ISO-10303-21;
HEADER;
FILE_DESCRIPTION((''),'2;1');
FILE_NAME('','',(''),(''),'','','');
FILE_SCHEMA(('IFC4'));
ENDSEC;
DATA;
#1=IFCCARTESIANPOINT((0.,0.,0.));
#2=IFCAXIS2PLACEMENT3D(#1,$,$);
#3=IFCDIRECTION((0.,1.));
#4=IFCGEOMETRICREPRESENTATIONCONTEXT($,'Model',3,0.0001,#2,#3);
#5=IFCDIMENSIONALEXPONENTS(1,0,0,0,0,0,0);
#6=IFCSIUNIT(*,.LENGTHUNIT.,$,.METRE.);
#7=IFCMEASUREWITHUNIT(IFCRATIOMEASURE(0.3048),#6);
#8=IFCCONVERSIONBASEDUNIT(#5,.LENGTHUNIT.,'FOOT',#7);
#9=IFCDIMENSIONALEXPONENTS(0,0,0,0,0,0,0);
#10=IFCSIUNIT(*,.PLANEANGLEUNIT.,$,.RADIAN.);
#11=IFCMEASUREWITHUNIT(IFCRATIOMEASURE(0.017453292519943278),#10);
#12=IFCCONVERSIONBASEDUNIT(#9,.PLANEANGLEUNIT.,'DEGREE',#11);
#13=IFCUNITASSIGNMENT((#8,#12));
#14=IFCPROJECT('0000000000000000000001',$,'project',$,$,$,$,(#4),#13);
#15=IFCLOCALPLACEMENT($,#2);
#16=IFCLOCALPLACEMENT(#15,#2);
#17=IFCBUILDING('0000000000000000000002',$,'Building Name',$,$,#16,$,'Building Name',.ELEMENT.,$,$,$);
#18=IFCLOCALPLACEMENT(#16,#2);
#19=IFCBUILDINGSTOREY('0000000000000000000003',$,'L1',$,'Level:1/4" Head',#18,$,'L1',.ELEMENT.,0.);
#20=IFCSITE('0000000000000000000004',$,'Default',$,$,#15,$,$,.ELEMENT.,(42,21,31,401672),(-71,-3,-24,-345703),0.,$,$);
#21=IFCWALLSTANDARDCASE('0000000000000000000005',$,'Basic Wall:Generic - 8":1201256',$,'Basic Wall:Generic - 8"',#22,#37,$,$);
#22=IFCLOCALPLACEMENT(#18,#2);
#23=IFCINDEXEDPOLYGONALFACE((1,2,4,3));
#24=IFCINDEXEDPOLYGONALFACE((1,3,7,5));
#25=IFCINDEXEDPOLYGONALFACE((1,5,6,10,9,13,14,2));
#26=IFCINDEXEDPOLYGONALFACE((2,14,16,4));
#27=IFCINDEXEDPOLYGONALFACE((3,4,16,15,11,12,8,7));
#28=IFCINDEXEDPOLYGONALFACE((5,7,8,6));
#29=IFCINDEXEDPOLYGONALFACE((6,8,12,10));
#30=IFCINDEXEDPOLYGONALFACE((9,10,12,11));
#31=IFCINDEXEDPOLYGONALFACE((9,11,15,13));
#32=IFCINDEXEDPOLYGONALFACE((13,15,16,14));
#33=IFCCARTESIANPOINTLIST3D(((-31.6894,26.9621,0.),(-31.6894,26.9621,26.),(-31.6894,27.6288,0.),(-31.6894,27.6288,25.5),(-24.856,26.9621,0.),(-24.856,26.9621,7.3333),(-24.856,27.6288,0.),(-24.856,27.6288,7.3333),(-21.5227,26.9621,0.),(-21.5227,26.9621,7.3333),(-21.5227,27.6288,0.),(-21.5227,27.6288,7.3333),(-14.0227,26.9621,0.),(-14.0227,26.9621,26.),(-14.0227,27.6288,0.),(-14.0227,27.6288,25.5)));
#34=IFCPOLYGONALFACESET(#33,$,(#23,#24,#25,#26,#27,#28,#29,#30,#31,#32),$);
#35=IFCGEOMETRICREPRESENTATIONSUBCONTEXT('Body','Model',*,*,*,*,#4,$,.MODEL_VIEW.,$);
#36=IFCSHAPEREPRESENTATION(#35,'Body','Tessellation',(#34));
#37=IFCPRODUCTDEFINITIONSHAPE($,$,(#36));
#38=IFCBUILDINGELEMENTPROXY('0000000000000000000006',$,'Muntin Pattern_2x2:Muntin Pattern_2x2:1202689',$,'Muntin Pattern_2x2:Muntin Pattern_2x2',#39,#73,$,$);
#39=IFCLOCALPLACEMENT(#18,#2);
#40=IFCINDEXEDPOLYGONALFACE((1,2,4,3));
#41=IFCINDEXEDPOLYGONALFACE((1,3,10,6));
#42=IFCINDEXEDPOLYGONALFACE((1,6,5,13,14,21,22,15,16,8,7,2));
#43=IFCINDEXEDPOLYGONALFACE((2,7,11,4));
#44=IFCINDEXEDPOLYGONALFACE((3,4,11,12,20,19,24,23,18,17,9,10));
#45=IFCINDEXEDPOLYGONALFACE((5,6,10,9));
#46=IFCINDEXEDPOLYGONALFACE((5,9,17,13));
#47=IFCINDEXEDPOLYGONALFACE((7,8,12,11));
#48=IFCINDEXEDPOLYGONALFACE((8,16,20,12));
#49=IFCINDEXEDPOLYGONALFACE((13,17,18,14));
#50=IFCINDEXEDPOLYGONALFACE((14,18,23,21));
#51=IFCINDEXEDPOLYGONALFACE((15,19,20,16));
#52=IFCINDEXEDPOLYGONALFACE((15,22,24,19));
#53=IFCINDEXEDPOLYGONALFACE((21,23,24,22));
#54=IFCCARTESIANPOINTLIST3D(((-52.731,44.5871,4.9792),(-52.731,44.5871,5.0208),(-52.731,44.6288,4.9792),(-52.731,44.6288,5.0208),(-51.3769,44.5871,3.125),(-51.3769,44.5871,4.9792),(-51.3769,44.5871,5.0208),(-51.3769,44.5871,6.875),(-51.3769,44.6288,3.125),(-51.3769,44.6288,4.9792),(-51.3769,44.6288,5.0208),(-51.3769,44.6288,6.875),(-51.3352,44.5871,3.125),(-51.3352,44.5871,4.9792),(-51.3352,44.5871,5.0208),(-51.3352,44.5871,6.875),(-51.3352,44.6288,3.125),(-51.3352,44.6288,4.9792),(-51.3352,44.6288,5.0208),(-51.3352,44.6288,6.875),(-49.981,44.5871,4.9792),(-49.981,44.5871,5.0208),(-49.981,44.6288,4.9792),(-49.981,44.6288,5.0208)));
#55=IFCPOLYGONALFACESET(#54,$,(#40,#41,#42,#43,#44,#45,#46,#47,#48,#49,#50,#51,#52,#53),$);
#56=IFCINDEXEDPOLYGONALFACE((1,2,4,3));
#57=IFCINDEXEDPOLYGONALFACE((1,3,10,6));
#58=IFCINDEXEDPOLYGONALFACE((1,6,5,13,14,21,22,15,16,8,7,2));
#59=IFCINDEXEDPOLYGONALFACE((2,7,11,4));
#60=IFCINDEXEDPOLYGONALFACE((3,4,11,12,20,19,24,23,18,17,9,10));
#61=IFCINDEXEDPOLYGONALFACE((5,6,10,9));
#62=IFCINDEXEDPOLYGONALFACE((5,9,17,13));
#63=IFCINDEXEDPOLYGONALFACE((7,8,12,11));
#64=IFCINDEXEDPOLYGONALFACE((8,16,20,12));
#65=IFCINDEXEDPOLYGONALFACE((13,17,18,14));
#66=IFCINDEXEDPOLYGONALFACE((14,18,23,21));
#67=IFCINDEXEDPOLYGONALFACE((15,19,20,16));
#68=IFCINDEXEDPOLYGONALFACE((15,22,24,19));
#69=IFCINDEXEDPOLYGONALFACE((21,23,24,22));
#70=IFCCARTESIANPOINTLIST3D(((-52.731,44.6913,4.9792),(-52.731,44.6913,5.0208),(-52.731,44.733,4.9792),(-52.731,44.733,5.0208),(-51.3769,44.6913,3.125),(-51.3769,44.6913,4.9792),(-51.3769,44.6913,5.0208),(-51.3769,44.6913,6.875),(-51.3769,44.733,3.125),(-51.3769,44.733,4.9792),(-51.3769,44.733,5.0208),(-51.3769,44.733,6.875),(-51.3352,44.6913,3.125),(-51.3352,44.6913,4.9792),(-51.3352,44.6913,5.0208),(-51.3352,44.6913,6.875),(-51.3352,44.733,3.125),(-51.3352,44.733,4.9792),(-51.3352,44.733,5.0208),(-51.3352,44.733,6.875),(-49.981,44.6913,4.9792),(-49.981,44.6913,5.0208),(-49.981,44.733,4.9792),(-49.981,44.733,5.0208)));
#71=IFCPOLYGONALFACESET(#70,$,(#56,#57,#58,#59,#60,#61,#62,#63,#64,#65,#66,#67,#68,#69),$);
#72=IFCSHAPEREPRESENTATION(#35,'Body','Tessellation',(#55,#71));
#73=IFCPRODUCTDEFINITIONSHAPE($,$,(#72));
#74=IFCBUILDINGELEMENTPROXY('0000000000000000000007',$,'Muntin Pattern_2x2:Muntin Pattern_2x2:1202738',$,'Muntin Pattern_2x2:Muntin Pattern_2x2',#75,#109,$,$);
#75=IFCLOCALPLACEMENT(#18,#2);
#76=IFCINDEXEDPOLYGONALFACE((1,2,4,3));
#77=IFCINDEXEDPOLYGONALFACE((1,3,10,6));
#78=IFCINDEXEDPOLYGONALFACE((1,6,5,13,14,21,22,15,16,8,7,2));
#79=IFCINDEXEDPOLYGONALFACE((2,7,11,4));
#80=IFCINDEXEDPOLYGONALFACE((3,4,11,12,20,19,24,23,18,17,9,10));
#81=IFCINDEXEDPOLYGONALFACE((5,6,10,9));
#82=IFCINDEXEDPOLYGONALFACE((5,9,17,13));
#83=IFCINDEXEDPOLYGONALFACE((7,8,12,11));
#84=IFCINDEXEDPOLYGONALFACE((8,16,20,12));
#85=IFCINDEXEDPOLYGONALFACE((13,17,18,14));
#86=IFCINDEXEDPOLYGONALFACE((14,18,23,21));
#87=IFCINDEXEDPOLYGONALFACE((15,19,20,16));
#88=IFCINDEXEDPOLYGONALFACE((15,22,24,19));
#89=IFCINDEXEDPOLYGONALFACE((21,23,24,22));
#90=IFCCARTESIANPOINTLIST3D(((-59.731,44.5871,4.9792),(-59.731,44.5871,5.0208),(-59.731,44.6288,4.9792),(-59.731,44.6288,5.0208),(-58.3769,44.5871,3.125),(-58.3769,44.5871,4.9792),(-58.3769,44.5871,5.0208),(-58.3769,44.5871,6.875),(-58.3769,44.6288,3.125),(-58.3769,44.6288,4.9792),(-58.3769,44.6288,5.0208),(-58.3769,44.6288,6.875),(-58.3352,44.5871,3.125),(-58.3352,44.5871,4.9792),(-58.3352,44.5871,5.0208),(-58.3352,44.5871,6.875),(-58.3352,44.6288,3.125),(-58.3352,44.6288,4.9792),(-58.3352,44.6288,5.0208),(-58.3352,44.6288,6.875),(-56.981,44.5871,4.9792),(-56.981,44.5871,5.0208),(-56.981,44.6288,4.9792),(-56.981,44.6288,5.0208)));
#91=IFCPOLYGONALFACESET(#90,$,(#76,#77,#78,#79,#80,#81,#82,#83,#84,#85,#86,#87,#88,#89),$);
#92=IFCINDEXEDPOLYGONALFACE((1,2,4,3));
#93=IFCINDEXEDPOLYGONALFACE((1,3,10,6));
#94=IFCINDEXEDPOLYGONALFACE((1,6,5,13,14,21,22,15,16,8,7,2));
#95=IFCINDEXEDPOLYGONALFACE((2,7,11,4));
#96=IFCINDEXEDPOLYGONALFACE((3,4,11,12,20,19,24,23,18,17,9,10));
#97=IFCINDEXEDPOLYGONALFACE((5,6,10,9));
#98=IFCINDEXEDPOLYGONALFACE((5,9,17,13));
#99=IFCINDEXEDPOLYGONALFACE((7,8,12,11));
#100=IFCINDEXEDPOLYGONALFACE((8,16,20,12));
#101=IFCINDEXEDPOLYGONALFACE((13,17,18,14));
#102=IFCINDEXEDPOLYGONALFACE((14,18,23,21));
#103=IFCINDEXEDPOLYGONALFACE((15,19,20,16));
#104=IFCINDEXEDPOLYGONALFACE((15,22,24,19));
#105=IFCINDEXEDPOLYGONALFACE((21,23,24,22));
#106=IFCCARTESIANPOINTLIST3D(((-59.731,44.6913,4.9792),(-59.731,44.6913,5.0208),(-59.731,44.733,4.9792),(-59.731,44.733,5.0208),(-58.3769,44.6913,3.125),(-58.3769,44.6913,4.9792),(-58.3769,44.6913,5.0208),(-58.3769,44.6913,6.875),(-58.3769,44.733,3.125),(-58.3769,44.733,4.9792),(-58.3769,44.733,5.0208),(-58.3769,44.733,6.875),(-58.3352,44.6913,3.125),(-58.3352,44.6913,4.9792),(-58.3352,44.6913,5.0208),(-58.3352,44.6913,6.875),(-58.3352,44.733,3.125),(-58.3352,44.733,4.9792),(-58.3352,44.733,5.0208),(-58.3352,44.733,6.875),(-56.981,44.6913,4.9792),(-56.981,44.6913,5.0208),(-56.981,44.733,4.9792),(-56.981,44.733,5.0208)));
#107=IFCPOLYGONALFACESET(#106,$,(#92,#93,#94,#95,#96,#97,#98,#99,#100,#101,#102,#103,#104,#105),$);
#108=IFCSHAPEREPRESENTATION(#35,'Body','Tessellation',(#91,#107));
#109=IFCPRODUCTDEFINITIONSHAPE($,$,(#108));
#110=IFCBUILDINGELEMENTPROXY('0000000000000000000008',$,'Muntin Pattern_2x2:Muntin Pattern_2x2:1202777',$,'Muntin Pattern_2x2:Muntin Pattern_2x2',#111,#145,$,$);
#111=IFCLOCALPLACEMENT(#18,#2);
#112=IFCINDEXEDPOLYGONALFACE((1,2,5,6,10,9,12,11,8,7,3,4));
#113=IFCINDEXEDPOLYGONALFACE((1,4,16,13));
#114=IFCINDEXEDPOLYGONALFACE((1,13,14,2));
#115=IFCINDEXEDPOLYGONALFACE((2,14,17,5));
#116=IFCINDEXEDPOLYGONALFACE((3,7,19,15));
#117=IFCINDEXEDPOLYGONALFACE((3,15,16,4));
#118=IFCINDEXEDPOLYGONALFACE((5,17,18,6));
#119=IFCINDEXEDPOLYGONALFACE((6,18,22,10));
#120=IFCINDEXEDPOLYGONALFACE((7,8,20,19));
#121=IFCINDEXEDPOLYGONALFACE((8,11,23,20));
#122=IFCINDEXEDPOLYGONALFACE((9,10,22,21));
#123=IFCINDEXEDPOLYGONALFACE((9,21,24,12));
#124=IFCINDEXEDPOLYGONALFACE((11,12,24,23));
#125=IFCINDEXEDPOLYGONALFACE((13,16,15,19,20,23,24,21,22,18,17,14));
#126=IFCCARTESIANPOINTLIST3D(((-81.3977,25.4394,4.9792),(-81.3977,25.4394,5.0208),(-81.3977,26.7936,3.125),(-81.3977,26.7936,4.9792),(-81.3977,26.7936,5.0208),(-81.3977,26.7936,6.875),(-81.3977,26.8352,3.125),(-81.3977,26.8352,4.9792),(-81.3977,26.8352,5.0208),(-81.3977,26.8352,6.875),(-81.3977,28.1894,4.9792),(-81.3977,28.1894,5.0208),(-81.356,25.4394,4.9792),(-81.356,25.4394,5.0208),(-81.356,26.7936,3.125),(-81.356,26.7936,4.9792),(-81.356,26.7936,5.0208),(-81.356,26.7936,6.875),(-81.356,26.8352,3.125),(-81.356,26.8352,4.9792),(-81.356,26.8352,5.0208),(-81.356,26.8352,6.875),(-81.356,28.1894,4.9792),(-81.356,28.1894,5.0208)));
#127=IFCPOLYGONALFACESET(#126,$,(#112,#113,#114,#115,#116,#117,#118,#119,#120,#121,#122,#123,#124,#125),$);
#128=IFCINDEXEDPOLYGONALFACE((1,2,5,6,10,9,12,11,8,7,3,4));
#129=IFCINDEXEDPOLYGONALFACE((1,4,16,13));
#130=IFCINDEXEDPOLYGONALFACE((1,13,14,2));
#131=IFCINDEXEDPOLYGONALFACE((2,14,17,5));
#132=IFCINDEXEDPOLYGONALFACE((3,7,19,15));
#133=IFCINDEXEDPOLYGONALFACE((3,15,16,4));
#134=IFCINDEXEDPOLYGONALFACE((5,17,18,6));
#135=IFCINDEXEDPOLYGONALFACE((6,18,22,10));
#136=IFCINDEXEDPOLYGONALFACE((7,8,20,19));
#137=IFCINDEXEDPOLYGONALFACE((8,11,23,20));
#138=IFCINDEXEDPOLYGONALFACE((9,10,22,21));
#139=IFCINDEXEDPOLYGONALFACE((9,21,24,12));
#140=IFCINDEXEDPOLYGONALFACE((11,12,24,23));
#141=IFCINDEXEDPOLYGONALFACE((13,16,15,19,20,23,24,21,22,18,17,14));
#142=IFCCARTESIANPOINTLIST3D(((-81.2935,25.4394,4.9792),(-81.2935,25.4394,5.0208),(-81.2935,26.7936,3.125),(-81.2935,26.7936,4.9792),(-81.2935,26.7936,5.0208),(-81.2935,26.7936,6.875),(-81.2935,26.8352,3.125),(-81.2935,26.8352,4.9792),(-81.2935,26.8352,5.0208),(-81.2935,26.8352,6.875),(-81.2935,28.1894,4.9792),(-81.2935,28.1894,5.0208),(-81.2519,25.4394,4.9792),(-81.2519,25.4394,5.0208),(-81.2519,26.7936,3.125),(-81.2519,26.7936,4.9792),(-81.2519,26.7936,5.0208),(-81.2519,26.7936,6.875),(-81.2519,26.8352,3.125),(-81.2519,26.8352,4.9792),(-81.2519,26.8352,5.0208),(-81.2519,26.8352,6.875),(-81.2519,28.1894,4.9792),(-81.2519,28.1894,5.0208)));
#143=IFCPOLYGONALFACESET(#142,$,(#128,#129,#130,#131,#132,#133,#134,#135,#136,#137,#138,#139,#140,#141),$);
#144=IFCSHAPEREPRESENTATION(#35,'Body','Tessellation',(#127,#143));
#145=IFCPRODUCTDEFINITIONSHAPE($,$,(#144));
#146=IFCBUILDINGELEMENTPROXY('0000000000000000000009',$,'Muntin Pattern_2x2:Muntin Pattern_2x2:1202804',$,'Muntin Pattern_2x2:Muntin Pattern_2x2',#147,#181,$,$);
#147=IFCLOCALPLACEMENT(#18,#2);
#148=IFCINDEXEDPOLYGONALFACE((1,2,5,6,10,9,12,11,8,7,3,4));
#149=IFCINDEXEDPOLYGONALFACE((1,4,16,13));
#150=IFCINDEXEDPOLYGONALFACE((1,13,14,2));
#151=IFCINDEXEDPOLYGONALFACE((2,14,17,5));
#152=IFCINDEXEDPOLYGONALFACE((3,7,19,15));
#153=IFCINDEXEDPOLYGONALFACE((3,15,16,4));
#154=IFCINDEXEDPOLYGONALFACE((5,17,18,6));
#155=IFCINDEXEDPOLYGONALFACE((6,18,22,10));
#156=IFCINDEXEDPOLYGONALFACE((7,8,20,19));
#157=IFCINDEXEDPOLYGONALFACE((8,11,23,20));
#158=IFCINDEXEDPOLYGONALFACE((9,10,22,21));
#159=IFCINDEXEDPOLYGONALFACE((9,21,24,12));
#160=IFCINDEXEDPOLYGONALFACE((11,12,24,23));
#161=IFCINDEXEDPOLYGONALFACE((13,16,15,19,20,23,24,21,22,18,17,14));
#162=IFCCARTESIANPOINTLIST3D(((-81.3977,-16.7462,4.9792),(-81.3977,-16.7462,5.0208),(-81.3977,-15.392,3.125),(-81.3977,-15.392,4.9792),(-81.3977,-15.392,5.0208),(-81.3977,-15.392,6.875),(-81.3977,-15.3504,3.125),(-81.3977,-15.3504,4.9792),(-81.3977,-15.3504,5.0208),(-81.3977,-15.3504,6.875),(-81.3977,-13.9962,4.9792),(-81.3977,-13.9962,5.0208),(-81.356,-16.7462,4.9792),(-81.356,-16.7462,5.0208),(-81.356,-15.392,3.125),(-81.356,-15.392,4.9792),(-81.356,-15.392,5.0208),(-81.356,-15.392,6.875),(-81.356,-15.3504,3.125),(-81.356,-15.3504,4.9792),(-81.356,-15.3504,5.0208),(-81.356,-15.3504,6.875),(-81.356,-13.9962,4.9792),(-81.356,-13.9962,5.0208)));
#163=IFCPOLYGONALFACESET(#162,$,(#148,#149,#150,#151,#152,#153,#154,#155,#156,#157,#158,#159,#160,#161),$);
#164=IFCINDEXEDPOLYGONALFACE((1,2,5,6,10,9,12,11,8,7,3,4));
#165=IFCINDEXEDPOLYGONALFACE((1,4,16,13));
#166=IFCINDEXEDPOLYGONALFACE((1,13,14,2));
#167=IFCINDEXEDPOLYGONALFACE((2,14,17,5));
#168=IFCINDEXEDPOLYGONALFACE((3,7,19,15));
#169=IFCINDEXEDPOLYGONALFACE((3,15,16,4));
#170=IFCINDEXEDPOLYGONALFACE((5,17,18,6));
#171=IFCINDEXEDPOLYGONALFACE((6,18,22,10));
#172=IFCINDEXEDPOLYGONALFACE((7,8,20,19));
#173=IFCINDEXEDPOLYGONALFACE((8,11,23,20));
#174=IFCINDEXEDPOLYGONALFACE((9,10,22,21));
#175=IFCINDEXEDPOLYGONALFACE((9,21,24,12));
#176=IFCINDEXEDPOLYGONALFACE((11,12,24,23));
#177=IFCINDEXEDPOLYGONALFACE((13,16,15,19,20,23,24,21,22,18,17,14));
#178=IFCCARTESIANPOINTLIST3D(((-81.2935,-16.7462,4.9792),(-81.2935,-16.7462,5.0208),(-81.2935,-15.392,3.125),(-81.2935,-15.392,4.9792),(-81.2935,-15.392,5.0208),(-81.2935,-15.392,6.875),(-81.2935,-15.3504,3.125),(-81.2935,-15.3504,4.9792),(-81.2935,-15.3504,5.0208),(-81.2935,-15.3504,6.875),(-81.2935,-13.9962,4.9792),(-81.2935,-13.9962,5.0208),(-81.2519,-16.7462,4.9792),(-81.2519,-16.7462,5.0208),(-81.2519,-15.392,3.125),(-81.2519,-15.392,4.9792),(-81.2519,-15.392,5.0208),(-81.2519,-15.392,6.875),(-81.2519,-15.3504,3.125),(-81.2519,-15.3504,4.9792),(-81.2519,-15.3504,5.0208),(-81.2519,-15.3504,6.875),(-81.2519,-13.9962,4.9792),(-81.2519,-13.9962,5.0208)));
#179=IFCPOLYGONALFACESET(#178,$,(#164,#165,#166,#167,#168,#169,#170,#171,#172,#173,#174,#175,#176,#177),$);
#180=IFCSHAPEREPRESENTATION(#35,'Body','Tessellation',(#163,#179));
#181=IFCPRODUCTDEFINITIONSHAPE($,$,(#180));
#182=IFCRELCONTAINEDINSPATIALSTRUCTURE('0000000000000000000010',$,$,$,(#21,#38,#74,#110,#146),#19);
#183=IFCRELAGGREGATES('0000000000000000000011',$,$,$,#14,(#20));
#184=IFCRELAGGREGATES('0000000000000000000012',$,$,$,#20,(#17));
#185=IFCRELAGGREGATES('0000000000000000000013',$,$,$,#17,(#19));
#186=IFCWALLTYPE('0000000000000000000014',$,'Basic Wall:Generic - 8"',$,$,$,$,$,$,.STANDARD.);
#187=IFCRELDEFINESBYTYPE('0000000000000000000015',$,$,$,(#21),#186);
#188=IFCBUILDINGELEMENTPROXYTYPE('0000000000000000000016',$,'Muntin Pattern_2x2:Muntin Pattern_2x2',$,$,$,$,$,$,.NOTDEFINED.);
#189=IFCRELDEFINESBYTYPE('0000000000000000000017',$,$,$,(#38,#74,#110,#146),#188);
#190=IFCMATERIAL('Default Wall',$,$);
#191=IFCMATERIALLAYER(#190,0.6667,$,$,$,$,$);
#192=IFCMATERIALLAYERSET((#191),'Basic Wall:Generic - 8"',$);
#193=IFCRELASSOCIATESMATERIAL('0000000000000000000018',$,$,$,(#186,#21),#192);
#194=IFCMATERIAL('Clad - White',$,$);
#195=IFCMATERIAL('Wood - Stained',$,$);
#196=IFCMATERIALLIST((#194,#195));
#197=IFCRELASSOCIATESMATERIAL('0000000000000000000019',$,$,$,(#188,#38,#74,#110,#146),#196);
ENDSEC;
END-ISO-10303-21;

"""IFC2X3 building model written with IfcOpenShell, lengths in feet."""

from ifc_helpers import new_model, entity, si_unit, converted_unit, direction, frame, frame_2d, origin, place, context, subcontext, project, spatial, polyline, rectangle, outline, extrude, clip, bounded_halfspace, source, transform, mapped, material, material_list, layer, layer_set, layer_usage, type_object, type_shapes, element, save


model = new_model("IFC2X3")

# Units and contexts
model_context = context("Model", 3, precision=0.0001, world=origin(), true_north=direction((0.0, 1.0)))
body_context = subcontext(model_context, "Body", "Model", "MODEL_VIEW")
ifc_project = project(units=[converted_unit("LENGTHUNIT", "FOOT", entity("IfcRatioMeasure", 0.3048), si_unit("LENGTHUNIT", "METRE"), dimensions=[1, 0, 0, 0, 0, 0, 0]), converted_unit("PLANEANGLEUNIT", "DEGREE", entity("IfcRatioMeasure", 0.017453292519943278), si_unit("PLANEANGLEUNIT", "RADIAN"), dimensions=[0, 0, 0, 0, 0, 0, 0])], contexts=[model_context])

# Site, building, storey
site_placement = place(None, origin())
site = spatial("IfcSite", under=ifc_project, at=site_placement, Name="Default", CompositionType="ELEMENT", RefLatitude=(42, 21, 31, 401672), RefLongitude=(-71, -3, -24, -345703), RefElevation=0.0)
building_placement = place(site_placement, origin())
building = spatial("IfcBuilding", under=site, at=building_placement, Name="Building Name", LongName="Building Name", CompositionType="ELEMENT")
storey_placement = place(building_placement, origin())
storey = spatial("IfcBuildingStorey", under=building, at=storey_placement, Name="L1", ObjectType="Level:1/4\" Head", LongName="L1", CompositionType="ELEMENT", Elevation=0.0)

# Shared definitions
ifc_material_1 = material(Name="Default Wall")
ifc_layer_1 = layer(ifc_material_1, 0.6667)
ifc_layer_set_1 = layer_set([ifc_layer_1], Name="Basic Wall:Generic - 8\"")
ifc_layer_usage_1 = layer_usage(ifc_layer_set_1, "AXIS2", "NEGATIVE", 0.3333)
wall_type_1 = type_object("IfcWallType", Name="Basic Wall:Generic - 8\"", PredefinedType="STANDARD", material=ifc_layer_set_1)

# Wall, opening
wall_1_placement = place(storey_placement, frame((-31.6894, 27.2955, 0.0)))
wall_1 = element("IfcWallStandardCase", 1, at=wall_1_placement, inside=storey, type_object=wall_type_1, material=ifc_layer_usage_1, Name="Basic Wall:Generic - 8\":1201256", ObjectType="Basic Wall:Generic - 8\"", context=body_context, shape_type="Clipping", body=[
    clip(extrude(rectangle(XDim=17.6667, YDim=0.6667, at=frame_2d((8.8333, 0.0), x_axis=(1.0, 0.0))), origin(), (0.0, 0.0, 1.0), 26.0), bounded_halfspace(frame((0.0, -0.3333, 26.0), z_axis=(0.0, 0.6, 0.8), x_axis=(-1.0, 0.0, 0.0)), False, frame((0.0, -0.3333, 26.0)), polyline([(0.0, 0.0), (17.6667, 0.0), (17.6667, 0.6667), (17.0, 0.6667), (0.0, 0.6667), (0.0, 0.0)]))),
])
opening_1_placement = place(wall_1_placement, frame((6.8333, -0.3333, 0.0)))
element("IfcOpeningElement", 2, at=opening_1_placement, cuts=wall_1, ObjectType="Opening", context=body_context, shape_type="SweptSolid", body=[
    extrude(rectangle(XDim=7.3333, YDim=3.3333, at=frame_2d((3.6667, 1.6667), x_axis=(1.0, 0.0))), frame((0.0, 0.0, 0.0), z_axis=(0.0, 1.0, 0.0), x_axis=(0.0, 0.0, 1.0)), (0.0, 0.0, 1.0), 0.6667),
])

# Building element proxies
ifc_material_2 = material(Name="Clad - White")
ifc_material_3 = material(Name="Wood - Stained")
ifc_material_list = material_list([ifc_material_2, ifc_material_3])
building_element_proxy_type_1 = type_object("IfcBuildingElementProxyType", Name="Muntin Pattern_2x2:Muntin Pattern_2x2", PredefinedType="NOTDEFINED", material=ifc_material_list)
shared_shape_1 = source(origin(), body_context, "Body", "SweptSolid", [
    extrude(outline(polyline([(0.0208, -0.0208), (1.875, -0.0208), (1.875, 0.0208), (0.0208, 0.0208), (0.0208, 1.375), (-0.0208, 1.375), (-0.0208, 0.0208), (-1.875, 0.0208), (-1.875, -0.0208), (-0.0208, -0.0208), (-0.0208, -1.375), (0.0208, -1.375), (0.0208, -0.0208)])), frame((0.0, -0.0729, 1.875), z_axis=(0.0, 1.0, 0.0), x_axis=(0.0, 0.0, 1.0)), (0.0, 0.0, 1.0), 0.0417),
    extrude(outline(polyline([(0.0208, -0.0208), (1.875, -0.0208), (1.875, 0.0208), (0.0208, 0.0208), (0.0208, 1.375), (-0.0208, 1.375), (-0.0208, 0.0208), (-1.875, 0.0208), (-1.875, -0.0208), (-0.0208, -0.0208), (-0.0208, -1.375), (0.0208, -1.375), (0.0208, -0.0208)])), frame((0.0, 0.0313, 1.875), z_axis=(0.0, 1.0, 0.0), x_axis=(0.0, 0.0, 1.0)), (0.0, 0.0, 1.0), 0.0417),
])
type_shapes(building_element_proxy_type_1, [shared_shape_1])
for number, where, name in (
    (3, (-51.356, 44.66, 3.125), "Muntin Pattern_2x2:Muntin Pattern_2x2:1202689"),
    (4, (-58.356, 44.66, 3.125), "Muntin Pattern_2x2:Muntin Pattern_2x2:1202738"),
):
    element("IfcBuildingElementProxy", number, at=place(storey_placement, frame(where)), inside=storey, type_object=building_element_proxy_type_1, material=ifc_material_list, Name=name, ObjectType="Muntin Pattern_2x2:Muntin Pattern_2x2", context=body_context, shape_type="MappedRepresentation", body=[
        mapped(shared_shape_1, transform((0.0, 0.0, 0.0), scale=1.0)),
    ])
for number, where, z_axis, x_axis, name in (
    (5, (-81.3248, 26.8144, 3.125), (0.0, 0.0, 1.0), (0.0, -1.0, 0.0), "Muntin Pattern_2x2:Muntin Pattern_2x2:1202777"),
    (6, (-81.3248, -15.3712, 3.125), (0.0, 0.0, 1.0), (0.0, -1.0, 0.0), "Muntin Pattern_2x2:Muntin Pattern_2x2:1202804"),
):
    element("IfcBuildingElementProxy", number, at=place(storey_placement, frame(where, z_axis=z_axis, x_axis=x_axis)), inside=storey, type_object=building_element_proxy_type_1, material=ifc_material_list, Name=name, ObjectType="Muntin Pattern_2x2:Muntin Pattern_2x2", context=body_context, shape_type="MappedRepresentation", body=[
        mapped(shared_shape_1, transform((0.0, 0.0, 0.0), scale=1.0)),
    ])

save(model, "model.ifc")
